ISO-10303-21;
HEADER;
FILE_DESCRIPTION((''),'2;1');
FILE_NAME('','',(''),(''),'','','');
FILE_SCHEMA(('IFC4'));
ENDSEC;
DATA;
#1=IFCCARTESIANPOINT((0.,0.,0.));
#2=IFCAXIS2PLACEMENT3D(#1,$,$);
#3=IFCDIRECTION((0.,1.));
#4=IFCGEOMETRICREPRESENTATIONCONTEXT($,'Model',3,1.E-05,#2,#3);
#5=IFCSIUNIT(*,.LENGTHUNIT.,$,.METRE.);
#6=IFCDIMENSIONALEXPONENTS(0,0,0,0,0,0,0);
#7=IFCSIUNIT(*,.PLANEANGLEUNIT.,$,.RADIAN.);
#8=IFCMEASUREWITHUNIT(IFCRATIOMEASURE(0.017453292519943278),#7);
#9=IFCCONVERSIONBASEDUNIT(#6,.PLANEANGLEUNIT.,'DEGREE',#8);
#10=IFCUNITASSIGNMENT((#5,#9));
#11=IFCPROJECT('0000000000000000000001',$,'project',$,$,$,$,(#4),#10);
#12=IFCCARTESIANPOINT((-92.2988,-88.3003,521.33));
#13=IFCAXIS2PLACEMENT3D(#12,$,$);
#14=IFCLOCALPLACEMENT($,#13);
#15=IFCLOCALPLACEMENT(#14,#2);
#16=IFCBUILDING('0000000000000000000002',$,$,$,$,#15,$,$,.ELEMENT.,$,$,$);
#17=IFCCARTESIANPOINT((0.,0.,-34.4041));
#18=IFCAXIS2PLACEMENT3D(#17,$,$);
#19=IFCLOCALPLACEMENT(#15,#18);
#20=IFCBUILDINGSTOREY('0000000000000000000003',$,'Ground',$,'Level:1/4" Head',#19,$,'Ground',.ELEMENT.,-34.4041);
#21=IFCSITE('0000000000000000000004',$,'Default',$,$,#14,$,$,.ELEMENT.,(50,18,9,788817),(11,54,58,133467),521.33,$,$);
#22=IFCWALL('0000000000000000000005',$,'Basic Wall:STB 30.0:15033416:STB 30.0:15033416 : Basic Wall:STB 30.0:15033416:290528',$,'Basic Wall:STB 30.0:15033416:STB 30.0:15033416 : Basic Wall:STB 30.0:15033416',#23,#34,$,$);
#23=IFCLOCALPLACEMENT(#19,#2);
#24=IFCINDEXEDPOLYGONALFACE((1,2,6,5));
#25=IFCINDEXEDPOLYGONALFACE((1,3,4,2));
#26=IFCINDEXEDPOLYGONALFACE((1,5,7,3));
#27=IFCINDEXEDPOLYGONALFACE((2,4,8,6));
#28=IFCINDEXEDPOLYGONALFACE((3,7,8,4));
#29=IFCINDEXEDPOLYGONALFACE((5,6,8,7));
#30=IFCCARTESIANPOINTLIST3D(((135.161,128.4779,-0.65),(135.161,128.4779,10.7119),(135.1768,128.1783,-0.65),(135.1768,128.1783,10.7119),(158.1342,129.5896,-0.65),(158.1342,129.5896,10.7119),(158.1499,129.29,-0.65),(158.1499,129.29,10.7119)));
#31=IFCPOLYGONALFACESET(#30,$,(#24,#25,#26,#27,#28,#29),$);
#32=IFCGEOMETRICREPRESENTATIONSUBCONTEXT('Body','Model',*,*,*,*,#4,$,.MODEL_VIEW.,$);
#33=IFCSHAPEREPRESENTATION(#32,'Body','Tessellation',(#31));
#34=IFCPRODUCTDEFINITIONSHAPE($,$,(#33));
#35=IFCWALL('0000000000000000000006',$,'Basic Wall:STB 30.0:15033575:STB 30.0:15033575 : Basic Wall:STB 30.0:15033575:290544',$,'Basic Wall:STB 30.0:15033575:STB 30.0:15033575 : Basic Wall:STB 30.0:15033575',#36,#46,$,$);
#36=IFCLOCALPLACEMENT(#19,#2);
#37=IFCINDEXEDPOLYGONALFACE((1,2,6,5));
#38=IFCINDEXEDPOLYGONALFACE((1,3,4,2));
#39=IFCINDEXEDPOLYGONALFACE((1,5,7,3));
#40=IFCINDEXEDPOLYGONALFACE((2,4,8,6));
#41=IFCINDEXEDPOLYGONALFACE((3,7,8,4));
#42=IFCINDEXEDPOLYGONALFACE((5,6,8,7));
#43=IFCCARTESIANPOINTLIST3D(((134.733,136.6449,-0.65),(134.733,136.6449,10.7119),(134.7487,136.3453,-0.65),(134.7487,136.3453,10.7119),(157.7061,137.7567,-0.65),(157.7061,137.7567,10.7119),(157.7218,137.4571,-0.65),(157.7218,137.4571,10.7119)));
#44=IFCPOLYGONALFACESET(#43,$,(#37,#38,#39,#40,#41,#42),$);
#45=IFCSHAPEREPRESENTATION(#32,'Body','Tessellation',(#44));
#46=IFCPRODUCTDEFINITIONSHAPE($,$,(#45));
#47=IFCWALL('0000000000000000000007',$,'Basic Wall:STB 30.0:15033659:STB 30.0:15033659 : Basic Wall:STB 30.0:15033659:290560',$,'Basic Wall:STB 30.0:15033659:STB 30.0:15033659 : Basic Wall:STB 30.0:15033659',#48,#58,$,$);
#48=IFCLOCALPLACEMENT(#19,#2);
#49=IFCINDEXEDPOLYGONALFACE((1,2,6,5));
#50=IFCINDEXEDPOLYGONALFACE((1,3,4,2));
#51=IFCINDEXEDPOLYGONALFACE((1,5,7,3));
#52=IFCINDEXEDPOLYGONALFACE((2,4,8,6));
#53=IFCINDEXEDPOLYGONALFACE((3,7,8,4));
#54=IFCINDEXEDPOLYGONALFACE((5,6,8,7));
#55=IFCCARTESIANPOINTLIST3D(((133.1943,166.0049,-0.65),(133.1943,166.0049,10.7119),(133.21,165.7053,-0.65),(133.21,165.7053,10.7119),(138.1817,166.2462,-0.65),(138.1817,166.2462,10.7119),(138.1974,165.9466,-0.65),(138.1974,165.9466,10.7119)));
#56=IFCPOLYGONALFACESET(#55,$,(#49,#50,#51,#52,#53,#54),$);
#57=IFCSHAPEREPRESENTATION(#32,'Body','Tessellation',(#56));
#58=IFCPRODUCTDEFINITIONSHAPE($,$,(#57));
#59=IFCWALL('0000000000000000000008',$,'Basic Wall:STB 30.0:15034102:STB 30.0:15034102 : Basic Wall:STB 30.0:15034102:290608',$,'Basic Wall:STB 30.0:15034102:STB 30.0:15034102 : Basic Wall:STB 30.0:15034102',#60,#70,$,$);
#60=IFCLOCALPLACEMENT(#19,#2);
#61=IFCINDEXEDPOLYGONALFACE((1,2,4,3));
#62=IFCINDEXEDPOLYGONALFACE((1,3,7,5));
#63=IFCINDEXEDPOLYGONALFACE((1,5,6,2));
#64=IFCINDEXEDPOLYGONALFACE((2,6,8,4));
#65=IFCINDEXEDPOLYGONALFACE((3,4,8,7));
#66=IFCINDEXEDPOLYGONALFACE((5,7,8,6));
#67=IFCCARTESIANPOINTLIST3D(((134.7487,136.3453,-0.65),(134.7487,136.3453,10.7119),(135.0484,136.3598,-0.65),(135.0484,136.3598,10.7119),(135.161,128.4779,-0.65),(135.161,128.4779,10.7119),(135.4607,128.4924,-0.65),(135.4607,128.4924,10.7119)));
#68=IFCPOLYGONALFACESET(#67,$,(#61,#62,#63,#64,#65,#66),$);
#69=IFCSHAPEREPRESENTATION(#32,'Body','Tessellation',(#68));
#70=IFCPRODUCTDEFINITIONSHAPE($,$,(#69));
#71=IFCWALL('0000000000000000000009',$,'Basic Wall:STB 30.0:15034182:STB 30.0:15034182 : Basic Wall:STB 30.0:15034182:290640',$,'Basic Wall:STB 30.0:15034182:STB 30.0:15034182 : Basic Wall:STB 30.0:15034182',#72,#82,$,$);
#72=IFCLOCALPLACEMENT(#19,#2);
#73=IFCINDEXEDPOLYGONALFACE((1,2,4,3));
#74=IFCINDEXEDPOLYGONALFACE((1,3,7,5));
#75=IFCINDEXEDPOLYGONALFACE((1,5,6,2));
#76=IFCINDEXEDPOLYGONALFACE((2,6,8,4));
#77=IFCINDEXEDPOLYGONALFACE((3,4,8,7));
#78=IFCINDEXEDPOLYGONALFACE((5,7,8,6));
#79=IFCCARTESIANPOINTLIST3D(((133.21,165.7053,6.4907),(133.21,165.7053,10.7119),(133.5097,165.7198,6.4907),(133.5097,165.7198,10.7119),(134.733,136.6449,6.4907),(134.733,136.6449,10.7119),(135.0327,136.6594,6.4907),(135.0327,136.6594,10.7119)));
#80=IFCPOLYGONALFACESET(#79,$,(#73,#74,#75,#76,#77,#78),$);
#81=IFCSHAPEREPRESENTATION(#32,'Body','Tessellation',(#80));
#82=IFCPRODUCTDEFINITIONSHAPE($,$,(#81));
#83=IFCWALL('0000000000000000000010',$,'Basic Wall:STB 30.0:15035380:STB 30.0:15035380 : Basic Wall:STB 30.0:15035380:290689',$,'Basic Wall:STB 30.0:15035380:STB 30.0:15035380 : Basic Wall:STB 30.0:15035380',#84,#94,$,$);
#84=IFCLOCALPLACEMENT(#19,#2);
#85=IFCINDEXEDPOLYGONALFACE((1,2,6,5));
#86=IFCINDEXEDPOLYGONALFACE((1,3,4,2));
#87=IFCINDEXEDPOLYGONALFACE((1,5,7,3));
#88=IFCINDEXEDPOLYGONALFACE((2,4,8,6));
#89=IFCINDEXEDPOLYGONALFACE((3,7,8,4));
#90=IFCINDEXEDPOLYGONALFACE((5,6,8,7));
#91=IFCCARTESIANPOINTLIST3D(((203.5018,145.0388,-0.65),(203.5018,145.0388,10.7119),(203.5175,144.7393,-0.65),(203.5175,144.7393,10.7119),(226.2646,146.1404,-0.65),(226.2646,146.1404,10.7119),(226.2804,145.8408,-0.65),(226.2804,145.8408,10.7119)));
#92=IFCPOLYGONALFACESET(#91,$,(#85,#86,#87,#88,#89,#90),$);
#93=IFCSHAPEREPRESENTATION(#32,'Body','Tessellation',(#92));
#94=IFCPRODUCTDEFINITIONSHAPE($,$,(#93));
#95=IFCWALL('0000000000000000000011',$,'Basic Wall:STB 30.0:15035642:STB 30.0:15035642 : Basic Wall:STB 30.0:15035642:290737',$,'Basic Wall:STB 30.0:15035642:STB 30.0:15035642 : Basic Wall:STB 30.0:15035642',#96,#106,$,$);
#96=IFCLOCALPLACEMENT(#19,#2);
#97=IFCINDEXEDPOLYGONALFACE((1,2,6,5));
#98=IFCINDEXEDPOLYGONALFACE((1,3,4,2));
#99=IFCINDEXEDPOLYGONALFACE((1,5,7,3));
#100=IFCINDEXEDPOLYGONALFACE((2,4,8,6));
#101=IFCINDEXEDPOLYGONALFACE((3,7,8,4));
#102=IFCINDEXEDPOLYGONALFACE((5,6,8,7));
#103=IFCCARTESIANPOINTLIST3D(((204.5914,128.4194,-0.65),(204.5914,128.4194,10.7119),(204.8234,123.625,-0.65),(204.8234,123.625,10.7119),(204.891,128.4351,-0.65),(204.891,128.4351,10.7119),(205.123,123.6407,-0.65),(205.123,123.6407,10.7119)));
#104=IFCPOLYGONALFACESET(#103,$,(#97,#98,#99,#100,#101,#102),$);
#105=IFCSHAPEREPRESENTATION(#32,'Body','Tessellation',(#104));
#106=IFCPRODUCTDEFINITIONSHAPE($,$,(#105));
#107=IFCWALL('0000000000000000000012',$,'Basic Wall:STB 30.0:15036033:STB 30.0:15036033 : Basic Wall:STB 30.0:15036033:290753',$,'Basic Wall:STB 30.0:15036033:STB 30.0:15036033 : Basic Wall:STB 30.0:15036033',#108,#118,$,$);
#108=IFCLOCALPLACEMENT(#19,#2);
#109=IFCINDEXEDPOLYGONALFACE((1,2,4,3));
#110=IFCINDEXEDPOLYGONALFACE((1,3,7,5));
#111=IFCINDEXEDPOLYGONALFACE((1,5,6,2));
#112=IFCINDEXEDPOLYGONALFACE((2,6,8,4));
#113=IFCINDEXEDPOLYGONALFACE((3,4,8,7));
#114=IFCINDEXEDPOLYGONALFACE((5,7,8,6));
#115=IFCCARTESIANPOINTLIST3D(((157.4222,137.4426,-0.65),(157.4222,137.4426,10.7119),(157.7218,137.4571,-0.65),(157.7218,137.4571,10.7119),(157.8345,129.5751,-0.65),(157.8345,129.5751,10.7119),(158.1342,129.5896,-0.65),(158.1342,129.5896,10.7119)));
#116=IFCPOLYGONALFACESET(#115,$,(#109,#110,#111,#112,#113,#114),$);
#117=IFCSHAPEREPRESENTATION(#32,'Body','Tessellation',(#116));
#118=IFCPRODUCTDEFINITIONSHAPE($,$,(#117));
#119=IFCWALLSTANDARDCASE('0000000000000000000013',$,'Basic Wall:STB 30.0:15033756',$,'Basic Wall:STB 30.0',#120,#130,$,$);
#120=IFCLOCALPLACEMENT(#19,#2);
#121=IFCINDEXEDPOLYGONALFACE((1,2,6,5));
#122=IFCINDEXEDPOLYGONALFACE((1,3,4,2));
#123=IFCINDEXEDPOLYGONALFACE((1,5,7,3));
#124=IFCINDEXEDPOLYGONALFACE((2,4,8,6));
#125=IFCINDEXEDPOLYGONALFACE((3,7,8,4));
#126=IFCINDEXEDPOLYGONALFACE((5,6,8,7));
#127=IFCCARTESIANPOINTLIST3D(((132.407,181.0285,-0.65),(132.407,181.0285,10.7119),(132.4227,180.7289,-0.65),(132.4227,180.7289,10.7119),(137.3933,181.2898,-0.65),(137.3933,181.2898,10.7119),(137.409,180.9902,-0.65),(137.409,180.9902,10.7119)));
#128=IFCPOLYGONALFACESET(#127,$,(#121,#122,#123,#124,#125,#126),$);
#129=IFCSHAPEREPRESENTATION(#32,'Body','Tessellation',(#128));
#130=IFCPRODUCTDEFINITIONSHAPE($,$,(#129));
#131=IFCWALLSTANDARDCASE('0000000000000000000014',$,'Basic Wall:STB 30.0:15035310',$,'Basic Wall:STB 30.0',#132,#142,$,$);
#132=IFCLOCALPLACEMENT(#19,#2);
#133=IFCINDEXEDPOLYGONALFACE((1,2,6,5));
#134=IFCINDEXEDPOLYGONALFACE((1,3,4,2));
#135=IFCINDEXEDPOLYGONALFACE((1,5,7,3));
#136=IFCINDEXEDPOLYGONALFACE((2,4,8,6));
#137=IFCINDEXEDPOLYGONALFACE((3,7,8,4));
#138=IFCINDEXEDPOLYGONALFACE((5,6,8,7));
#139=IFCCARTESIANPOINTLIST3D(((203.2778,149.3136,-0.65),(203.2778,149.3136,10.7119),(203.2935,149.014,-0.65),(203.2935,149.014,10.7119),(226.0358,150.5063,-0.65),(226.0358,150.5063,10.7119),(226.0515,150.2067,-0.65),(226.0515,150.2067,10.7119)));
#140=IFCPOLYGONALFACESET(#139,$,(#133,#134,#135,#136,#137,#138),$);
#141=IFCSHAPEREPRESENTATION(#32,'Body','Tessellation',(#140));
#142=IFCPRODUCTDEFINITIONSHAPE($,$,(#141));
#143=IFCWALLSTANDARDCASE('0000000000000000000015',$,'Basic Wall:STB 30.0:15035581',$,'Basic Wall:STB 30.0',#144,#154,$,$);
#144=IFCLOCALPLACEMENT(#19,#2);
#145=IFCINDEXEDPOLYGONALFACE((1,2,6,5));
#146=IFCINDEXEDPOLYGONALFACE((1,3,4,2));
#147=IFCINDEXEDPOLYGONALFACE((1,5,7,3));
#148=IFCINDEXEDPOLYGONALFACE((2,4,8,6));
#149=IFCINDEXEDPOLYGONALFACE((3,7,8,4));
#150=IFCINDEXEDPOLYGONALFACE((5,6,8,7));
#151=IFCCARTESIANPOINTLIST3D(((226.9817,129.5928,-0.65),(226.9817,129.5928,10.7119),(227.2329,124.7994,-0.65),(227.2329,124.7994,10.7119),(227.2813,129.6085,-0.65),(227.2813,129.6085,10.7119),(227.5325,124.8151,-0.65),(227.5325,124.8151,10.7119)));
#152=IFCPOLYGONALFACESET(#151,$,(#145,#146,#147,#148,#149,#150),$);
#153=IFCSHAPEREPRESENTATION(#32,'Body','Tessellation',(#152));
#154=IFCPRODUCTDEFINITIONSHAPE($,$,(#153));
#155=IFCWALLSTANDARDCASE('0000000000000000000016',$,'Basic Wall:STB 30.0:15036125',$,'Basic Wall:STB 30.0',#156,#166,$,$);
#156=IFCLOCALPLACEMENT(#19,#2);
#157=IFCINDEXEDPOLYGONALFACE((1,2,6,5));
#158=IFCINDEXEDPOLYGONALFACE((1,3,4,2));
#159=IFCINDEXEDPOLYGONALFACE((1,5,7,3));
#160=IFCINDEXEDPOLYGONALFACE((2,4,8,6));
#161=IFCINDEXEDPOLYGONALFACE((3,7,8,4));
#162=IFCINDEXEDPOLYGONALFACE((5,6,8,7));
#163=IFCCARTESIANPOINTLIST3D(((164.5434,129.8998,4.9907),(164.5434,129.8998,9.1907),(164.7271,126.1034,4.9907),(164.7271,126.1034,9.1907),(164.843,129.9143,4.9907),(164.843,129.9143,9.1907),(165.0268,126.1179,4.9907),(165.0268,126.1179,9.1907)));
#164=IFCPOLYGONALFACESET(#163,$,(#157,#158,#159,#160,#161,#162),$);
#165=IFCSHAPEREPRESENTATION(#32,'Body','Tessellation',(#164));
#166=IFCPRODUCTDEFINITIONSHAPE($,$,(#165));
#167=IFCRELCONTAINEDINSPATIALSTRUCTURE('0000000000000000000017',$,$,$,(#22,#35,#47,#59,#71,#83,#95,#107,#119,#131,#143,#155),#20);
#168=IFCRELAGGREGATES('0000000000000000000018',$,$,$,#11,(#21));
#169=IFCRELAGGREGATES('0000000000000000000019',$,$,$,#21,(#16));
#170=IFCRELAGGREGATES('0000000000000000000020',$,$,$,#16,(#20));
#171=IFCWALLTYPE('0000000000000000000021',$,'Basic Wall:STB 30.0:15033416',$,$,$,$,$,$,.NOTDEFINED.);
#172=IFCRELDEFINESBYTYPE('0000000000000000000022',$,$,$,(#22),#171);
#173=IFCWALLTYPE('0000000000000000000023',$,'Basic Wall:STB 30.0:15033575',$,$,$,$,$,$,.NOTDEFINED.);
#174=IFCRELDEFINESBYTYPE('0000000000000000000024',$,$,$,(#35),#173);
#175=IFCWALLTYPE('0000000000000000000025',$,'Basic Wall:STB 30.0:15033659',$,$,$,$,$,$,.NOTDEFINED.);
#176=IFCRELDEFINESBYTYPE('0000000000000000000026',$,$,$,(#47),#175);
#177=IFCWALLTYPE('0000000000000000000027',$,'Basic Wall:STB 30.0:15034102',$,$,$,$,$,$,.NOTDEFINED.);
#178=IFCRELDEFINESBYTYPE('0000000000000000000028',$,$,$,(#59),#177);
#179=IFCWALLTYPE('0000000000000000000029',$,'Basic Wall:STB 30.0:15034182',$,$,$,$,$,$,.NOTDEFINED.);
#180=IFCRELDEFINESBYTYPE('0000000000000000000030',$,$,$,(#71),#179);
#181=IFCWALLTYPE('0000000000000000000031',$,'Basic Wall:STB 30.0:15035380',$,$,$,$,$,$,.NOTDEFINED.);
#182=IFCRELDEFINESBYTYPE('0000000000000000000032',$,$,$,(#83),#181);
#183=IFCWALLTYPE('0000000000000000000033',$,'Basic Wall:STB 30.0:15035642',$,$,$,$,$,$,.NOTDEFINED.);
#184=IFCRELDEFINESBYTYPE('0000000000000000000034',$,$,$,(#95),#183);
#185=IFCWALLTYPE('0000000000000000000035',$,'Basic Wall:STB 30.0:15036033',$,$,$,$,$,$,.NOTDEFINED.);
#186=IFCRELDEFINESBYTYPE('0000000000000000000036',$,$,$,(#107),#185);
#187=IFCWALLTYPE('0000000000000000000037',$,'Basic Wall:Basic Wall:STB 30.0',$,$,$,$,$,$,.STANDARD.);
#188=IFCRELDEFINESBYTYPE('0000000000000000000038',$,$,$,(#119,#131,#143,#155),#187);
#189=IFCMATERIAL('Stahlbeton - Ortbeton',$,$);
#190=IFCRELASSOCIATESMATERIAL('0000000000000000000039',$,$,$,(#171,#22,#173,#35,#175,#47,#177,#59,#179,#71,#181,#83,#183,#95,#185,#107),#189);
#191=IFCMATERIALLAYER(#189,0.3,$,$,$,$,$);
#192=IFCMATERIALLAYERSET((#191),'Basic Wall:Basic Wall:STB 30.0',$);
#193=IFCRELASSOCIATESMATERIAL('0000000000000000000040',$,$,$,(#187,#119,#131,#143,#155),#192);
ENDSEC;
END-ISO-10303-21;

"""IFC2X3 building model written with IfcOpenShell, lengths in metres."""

from ifc_helpers import new_model, entity, si_unit, converted_unit, direction, frame, frame_2d, origin, place, context, subcontext, project, spatial, polyline, rectangle, outline, extrude, material, layer, layer_set, layer_usage, type_object, element, save


model = new_model("IFC2X3")

# Units and contexts
model_context = context("Model", 3, precision=1e-05, world=origin(), true_north=direction((0.0, 1.0)))
body_context = subcontext(model_context, "Body", "Model", "MODEL_VIEW")
ifc_project = project(units=[si_unit("LENGTHUNIT", "METRE"), converted_unit("PLANEANGLEUNIT", "DEGREE", entity("IfcRatioMeasure", 0.017453292519943278), si_unit("PLANEANGLEUNIT", "RADIAN"), dimensions=[0, 0, 0, 0, 0, 0, 0])], contexts=[model_context])

# Site, building, storey
site_placement = place(None, frame((-92.2988, -88.3003, 521.33)))
site = spatial("IfcSite", under=ifc_project, at=site_placement, Name="Default", CompositionType="ELEMENT", RefLatitude=(50, 18, 9, 788817), RefLongitude=(11, 54, 58, 133467), RefElevation=521.33)
building_placement = place(site_placement, origin())
building = spatial("IfcBuilding", under=site, at=building_placement, CompositionType="ELEMENT")
storey_placement = place(building_placement, frame((0.0, 0.0, -34.4041)))
storey = spatial("IfcBuildingStorey", under=building, at=storey_placement, Name="Ground", ObjectType="Level:1/4\" Head", LongName="Ground", CompositionType="ELEMENT", Elevation=-34.4041)

# Walls
ifc_material_1 = material(Name="Stahlbeton - Ortbeton")
wall_type_1 = type_object("IfcWallType", Name="Basic Wall:STB 30.0:15033416", PredefinedType="NOTDEFINED", material=ifc_material_1)
wall_1_placement = place(storey_placement, frame((135.161, 128.1783, -0.65)))
element("IfcWall", 1, at=wall_1_placement, inside=storey, type_object=wall_type_1, material=ifc_material_1, Name="Basic Wall:STB 30.0:15033416:STB 30.0:15033416 : Basic Wall:STB 30.0:15033416:290528", ObjectType="Basic Wall:STB 30.0:15033416:STB 30.0:15033416 : Basic Wall:STB 30.0:15033416", context=body_context, shape_type="SweptSolid", body=[
    extrude(outline(polyline([(-11.4994, -0.15), (11.5006, -0.15), (11.4994, 0.15), (-11.5006, 0.15), (-11.4994, -0.15)])), frame((11.4944, 0.7057, 0.0), z_axis=(0.0, 0.0, 1.0), x_axis=(-0.998831, -0.048337, 0.0)), (0.0, 0.0, 1.0), 11.3619),
])
wall_type_2 = type_object("IfcWallType", Name="Basic Wall:STB 30.0:15033575", PredefinedType="NOTDEFINED", material=ifc_material_1)
wall_2_placement = place(storey_placement, frame((134.733, 136.3453, -0.65)))
element("IfcWall", 2, at=wall_2_placement, inside=storey, type_object=wall_type_2, material=ifc_material_1, Name="Basic Wall:STB 30.0:15033575:STB 30.0:15033575 : Basic Wall:STB 30.0:15033575:290544", ObjectType="Basic Wall:STB 30.0:15033575:STB 30.0:15033575 : Basic Wall:STB 30.0:15033575", context=body_context, shape_type="SweptSolid", body=[
    extrude(outline(polyline([(-11.4994, -0.15), (11.5006, -0.15), (11.4994, 0.15), (-11.5006, 0.15), (-11.4994, -0.15)])), frame((11.4944, 0.7057, 0.0), z_axis=(0.0, 0.0, 1.0), x_axis=(-0.998831, -0.048337, 0.0)), (0.0, 0.0, 1.0), 11.3619),
])
wall_type_3 = type_object("IfcWallType", Name="Basic Wall:STB 30.0:15033659", PredefinedType="NOTDEFINED", material=ifc_material_1)
wall_3_placement = place(storey_placement, frame((133.1943, 165.7053, -0.65)))
element("IfcWall", 3, at=wall_3_placement, inside=storey, type_object=wall_type_3, material=ifc_material_1, Name="Basic Wall:STB 30.0:15033659:STB 30.0:15033659 : Basic Wall:STB 30.0:15033659:290560", ObjectType="Basic Wall:STB 30.0:15033659:STB 30.0:15033659 : Basic Wall:STB 30.0:15033659", context=body_context, shape_type="SweptSolid", body=[
    extrude(outline(polyline([(-2.496, -0.15), (2.4972, -0.15), (2.496, 0.15), (-2.4972, 0.15), (-2.496, -0.15)])), frame((2.5015, 0.2705, 0.0), z_axis=(0.0, 0.0, 1.0), x_axis=(-0.998831, -0.048337, 0.0)), (0.0, 0.0, 1.0), 11.3619),
])
wall_type_4 = type_object("IfcWallType", Name="Basic Wall:STB 30.0:15034102", PredefinedType="NOTDEFINED", material=ifc_material_1)
wall_4_placement = place(storey_placement, frame((134.7487, 128.4779, -0.65), z_axis=(0.0, 0.0, 1.0), x_axis=(0.0, 1.0, 0.0)))
element("IfcWall", 4, at=wall_4_placement, inside=storey, type_object=wall_type_4, material=ifc_material_1, Name="Basic Wall:STB 30.0:15034102:STB 30.0:15034102 : Basic Wall:STB 30.0:15034102:290608", ObjectType="Basic Wall:STB 30.0:15034102:STB 30.0:15034102 : Basic Wall:STB 30.0:15034102", context=body_context, shape_type="SweptSolid", body=[
    extrude(outline(polyline([(-3.9397, -0.15), (3.9385, -0.15), (3.9397, 0.15), (-3.9385, 0.15), (-3.9397, -0.15)])), frame((3.941, -0.356, 0.0), z_axis=(0.0, 0.0, 1.0), x_axis=(0.99863, 0.052336, 0.0)), (0.0, 0.0, 1.0), 11.3619),
])
wall_type_5 = type_object("IfcWallType", Name="Basic Wall:STB 30.0:15034182", PredefinedType="NOTDEFINED", material=ifc_material_1)
wall_5_placement = place(storey_placement, frame((133.21, 136.6449, 6.4907), z_axis=(0.0, 0.0, 1.0), x_axis=(0.0, 1.0, 0.0)))
element("IfcWall", 5, at=wall_5_placement, inside=storey, type_object=wall_type_5, material=ifc_material_1, Name="Basic Wall:STB 30.0:15034182:STB 30.0:15034182 : Basic Wall:STB 30.0:15034182:290640", ObjectType="Basic Wall:STB 30.0:15034182:STB 30.0:15034182 : Basic Wall:STB 30.0:15034182", context=body_context, shape_type="SweptSolid", body=[
    extrude(outline(polyline([(-14.5507, -0.15), (14.5495, -0.15), (14.5507, 0.15), (-14.5495, 0.15), (-14.5507, -0.15)])), frame((14.5374, -0.9113, 0.0), z_axis=(0.0, 0.0, 1.0), x_axis=(0.99863, 0.052336, 0.0)), (0.0, 0.0, 1.0), 4.2212),
])
wall_type_6 = type_object("IfcWallType", Name="Basic Wall:STB 30.0:15035380", PredefinedType="NOTDEFINED", material=ifc_material_1)
wall_6_placement = place(storey_placement, frame((203.5018, 144.7393, -0.65)))
element("IfcWall", 6, at=wall_6_placement, inside=storey, type_object=wall_type_6, material=ifc_material_1, Name="Basic Wall:STB 30.0:15035380:STB 30.0:15035380 : Basic Wall:STB 30.0:15035380:290689", ObjectType="Basic Wall:STB 30.0:15035380:STB 30.0:15035380 : Basic Wall:STB 30.0:15035380", context=body_context, shape_type="SweptSolid", body=[
    extrude(outline(polyline([(-11.3941, -0.15), (11.3953, -0.15), (11.3941, 0.15), (-11.3953, 0.15), (-11.3941, -0.15)])), frame((11.3893, 0.7006, 0.0), z_axis=(0.0, 0.0, 1.0), x_axis=(-0.998831, -0.048337, 0.0)), (0.0, 0.0, 1.0), 11.3619),
])
wall_type_7 = type_object("IfcWallType", Name="Basic Wall:STB 30.0:15035642", PredefinedType="NOTDEFINED", material=ifc_material_1)
wall_7_placement = place(storey_placement, frame((204.5914, 123.625, -0.65), z_axis=(0.0, 0.0, 1.0), x_axis=(0.0, 1.0, 0.0)))
element("IfcWall", 7, at=wall_7_placement, inside=storey, type_object=wall_type_7, material=ifc_material_1, Name="Basic Wall:STB 30.0:15035642:STB 30.0:15035642 : Basic Wall:STB 30.0:15035642:290737", ObjectType="Basic Wall:STB 30.0:15035642:STB 30.0:15035642 : Basic Wall:STB 30.0:15035642", context=body_context, shape_type="SweptSolid", body=[
    extrude(outline(polyline([(-2.3994, -0.15), (2.4006, -0.15), (2.3994, 0.15), (-2.4006, 0.15), (-2.3994, -0.15)])), frame((2.4051, -0.2658, 0.0), z_axis=(0.0, 0.0, 1.0), x_axis=(-0.998831, -0.048337, 0.0)), (0.0, 0.0, 1.0), 11.3619),
])
wall_type_8 = type_object("IfcWallType", Name="Basic Wall:STB 30.0:15036033", PredefinedType="NOTDEFINED", material=ifc_material_1)
wall_8_placement = place(storey_placement, frame((157.4222, 129.5751, -0.65), z_axis=(0.0, 0.0, 1.0), x_axis=(0.0, 1.0, 0.0)))
element("IfcWall", 8, at=wall_8_placement, inside=storey, type_object=wall_type_8, material=ifc_material_1, Name="Basic Wall:STB 30.0:15036033:STB 30.0:15036033 : Basic Wall:STB 30.0:15036033:290753", ObjectType="Basic Wall:STB 30.0:15036033:STB 30.0:15036033 : Basic Wall:STB 30.0:15036033", context=body_context, shape_type="SweptSolid", body=[
    extrude(outline(polyline([(-3.9397, -0.15), (3.9385, -0.15), (3.9397, 0.15), (-3.9385, 0.15), (-3.9397, -0.15)])), frame((3.941, -0.356, 0.0), z_axis=(0.0, 0.0, 1.0), x_axis=(-0.99863, -0.052336, 0.0)), (0.0, 0.0, 1.0), 11.3619),
])
ifc_layer_1 = layer(ifc_material_1, 0.3)
ifc_layer_set_1 = layer_set([ifc_layer_1], Name="Basic Wall:Basic Wall:STB 30.0")
ifc_layer_usage_1 = layer_usage(ifc_layer_set_1, "AXIS2", "NEGATIVE", 0.15)
wall_type_9 = type_object("IfcWallType", Name="Basic Wall:Basic Wall:STB 30.0", PredefinedType="STANDARD", material=ifc_layer_set_1)
wall_9_placement = place(storey_placement, frame((132.4148, 180.8787, -0.65), z_axis=(0.0, 0.0, 1.0), x_axis=(0.99863, 0.052336, 0.0)))
element("IfcWallStandardCase", 9, at=wall_9_placement, inside=storey, type_object=wall_type_9, material=ifc_layer_usage_1, Name="Basic Wall:STB 30.0:15033756", ObjectType="Basic Wall:STB 30.0", context=body_context, shape_type="SweptSolid", body=[
    extrude(rectangle(XDim=4.9931, YDim=0.3, at=frame_2d((2.4966, 0.0), x_axis=(-1.0, 0.0))), origin(), (0.0, 0.0, 1.0), 11.3619),
])
ifc_layer_usage_2 = layer_usage(ifc_layer_set_1, "AXIS2", "NEGATIVE", 0.15)
wall_10_placement = place(storey_placement, frame((203.2857, 149.1638, -0.65), z_axis=(0.0, 0.0, 1.0), x_axis=(0.99863, 0.052336, 0.0)))
element("IfcWallStandardCase", 10, at=wall_10_placement, inside=storey, type_object=wall_type_9, material=ifc_layer_usage_2, Name="Basic Wall:STB 30.0:15035310", ObjectType="Basic Wall:STB 30.0", context=body_context, shape_type="SweptSolid", body=[
    extrude(rectangle(XDim=22.7893, YDim=0.3, at=frame_2d((11.3946, 0.0), x_axis=(-1.0, 0.0))), origin(), (0.0, 0.0, 1.0), 11.3619),
])
ifc_layer_usage_3 = layer_usage(ifc_layer_set_1, "AXIS2", "NEGATIVE", 0.15)
wall_11_placement = place(storey_placement, frame((227.3827, 124.8073, -0.65), z_axis=(0.0, 0.0, 1.0), x_axis=(-0.052336, 0.99863, 0.0)))
element("IfcWallStandardCase", 11, at=wall_11_placement, inside=storey, type_object=wall_type_9, material=ifc_layer_usage_3, Name="Basic Wall:STB 30.0:15035581", ObjectType="Basic Wall:STB 30.0", context=body_context, shape_type="SweptSolid", body=[
    extrude(rectangle(XDim=4.8, YDim=0.3, at=frame_2d((2.4, 0.0), x_axis=(-1.0, 0.0))), origin(), (0.0, 0.0, 1.0), 11.3619),
])
ifc_layer_usage_4 = layer_usage(ifc_layer_set_1, "AXIS2", "NEGATIVE", 0.15)
wall_12_placement = place(storey_placement, frame((164.8769, 126.1107, 4.9907), z_axis=(0.0, 0.0, 1.0), x_axis=(-0.048337, 0.998831, 0.0)))
element("IfcWallStandardCase", 12, at=wall_12_placement, inside=storey, type_object=wall_type_9, material=ifc_layer_usage_4, Name="Basic Wall:STB 30.0:15036125", ObjectType="Basic Wall:STB 30.0", context=body_context, shape_type="SweptSolid", body=[
    extrude(rectangle(XDim=3.8008, YDim=0.3, at=frame_2d((1.9004, 0.0), x_axis=(-1.0, 0.0))), origin(), (0.0, 0.0, 1.0), 4.2),
])

save(model, "model.ifc")
